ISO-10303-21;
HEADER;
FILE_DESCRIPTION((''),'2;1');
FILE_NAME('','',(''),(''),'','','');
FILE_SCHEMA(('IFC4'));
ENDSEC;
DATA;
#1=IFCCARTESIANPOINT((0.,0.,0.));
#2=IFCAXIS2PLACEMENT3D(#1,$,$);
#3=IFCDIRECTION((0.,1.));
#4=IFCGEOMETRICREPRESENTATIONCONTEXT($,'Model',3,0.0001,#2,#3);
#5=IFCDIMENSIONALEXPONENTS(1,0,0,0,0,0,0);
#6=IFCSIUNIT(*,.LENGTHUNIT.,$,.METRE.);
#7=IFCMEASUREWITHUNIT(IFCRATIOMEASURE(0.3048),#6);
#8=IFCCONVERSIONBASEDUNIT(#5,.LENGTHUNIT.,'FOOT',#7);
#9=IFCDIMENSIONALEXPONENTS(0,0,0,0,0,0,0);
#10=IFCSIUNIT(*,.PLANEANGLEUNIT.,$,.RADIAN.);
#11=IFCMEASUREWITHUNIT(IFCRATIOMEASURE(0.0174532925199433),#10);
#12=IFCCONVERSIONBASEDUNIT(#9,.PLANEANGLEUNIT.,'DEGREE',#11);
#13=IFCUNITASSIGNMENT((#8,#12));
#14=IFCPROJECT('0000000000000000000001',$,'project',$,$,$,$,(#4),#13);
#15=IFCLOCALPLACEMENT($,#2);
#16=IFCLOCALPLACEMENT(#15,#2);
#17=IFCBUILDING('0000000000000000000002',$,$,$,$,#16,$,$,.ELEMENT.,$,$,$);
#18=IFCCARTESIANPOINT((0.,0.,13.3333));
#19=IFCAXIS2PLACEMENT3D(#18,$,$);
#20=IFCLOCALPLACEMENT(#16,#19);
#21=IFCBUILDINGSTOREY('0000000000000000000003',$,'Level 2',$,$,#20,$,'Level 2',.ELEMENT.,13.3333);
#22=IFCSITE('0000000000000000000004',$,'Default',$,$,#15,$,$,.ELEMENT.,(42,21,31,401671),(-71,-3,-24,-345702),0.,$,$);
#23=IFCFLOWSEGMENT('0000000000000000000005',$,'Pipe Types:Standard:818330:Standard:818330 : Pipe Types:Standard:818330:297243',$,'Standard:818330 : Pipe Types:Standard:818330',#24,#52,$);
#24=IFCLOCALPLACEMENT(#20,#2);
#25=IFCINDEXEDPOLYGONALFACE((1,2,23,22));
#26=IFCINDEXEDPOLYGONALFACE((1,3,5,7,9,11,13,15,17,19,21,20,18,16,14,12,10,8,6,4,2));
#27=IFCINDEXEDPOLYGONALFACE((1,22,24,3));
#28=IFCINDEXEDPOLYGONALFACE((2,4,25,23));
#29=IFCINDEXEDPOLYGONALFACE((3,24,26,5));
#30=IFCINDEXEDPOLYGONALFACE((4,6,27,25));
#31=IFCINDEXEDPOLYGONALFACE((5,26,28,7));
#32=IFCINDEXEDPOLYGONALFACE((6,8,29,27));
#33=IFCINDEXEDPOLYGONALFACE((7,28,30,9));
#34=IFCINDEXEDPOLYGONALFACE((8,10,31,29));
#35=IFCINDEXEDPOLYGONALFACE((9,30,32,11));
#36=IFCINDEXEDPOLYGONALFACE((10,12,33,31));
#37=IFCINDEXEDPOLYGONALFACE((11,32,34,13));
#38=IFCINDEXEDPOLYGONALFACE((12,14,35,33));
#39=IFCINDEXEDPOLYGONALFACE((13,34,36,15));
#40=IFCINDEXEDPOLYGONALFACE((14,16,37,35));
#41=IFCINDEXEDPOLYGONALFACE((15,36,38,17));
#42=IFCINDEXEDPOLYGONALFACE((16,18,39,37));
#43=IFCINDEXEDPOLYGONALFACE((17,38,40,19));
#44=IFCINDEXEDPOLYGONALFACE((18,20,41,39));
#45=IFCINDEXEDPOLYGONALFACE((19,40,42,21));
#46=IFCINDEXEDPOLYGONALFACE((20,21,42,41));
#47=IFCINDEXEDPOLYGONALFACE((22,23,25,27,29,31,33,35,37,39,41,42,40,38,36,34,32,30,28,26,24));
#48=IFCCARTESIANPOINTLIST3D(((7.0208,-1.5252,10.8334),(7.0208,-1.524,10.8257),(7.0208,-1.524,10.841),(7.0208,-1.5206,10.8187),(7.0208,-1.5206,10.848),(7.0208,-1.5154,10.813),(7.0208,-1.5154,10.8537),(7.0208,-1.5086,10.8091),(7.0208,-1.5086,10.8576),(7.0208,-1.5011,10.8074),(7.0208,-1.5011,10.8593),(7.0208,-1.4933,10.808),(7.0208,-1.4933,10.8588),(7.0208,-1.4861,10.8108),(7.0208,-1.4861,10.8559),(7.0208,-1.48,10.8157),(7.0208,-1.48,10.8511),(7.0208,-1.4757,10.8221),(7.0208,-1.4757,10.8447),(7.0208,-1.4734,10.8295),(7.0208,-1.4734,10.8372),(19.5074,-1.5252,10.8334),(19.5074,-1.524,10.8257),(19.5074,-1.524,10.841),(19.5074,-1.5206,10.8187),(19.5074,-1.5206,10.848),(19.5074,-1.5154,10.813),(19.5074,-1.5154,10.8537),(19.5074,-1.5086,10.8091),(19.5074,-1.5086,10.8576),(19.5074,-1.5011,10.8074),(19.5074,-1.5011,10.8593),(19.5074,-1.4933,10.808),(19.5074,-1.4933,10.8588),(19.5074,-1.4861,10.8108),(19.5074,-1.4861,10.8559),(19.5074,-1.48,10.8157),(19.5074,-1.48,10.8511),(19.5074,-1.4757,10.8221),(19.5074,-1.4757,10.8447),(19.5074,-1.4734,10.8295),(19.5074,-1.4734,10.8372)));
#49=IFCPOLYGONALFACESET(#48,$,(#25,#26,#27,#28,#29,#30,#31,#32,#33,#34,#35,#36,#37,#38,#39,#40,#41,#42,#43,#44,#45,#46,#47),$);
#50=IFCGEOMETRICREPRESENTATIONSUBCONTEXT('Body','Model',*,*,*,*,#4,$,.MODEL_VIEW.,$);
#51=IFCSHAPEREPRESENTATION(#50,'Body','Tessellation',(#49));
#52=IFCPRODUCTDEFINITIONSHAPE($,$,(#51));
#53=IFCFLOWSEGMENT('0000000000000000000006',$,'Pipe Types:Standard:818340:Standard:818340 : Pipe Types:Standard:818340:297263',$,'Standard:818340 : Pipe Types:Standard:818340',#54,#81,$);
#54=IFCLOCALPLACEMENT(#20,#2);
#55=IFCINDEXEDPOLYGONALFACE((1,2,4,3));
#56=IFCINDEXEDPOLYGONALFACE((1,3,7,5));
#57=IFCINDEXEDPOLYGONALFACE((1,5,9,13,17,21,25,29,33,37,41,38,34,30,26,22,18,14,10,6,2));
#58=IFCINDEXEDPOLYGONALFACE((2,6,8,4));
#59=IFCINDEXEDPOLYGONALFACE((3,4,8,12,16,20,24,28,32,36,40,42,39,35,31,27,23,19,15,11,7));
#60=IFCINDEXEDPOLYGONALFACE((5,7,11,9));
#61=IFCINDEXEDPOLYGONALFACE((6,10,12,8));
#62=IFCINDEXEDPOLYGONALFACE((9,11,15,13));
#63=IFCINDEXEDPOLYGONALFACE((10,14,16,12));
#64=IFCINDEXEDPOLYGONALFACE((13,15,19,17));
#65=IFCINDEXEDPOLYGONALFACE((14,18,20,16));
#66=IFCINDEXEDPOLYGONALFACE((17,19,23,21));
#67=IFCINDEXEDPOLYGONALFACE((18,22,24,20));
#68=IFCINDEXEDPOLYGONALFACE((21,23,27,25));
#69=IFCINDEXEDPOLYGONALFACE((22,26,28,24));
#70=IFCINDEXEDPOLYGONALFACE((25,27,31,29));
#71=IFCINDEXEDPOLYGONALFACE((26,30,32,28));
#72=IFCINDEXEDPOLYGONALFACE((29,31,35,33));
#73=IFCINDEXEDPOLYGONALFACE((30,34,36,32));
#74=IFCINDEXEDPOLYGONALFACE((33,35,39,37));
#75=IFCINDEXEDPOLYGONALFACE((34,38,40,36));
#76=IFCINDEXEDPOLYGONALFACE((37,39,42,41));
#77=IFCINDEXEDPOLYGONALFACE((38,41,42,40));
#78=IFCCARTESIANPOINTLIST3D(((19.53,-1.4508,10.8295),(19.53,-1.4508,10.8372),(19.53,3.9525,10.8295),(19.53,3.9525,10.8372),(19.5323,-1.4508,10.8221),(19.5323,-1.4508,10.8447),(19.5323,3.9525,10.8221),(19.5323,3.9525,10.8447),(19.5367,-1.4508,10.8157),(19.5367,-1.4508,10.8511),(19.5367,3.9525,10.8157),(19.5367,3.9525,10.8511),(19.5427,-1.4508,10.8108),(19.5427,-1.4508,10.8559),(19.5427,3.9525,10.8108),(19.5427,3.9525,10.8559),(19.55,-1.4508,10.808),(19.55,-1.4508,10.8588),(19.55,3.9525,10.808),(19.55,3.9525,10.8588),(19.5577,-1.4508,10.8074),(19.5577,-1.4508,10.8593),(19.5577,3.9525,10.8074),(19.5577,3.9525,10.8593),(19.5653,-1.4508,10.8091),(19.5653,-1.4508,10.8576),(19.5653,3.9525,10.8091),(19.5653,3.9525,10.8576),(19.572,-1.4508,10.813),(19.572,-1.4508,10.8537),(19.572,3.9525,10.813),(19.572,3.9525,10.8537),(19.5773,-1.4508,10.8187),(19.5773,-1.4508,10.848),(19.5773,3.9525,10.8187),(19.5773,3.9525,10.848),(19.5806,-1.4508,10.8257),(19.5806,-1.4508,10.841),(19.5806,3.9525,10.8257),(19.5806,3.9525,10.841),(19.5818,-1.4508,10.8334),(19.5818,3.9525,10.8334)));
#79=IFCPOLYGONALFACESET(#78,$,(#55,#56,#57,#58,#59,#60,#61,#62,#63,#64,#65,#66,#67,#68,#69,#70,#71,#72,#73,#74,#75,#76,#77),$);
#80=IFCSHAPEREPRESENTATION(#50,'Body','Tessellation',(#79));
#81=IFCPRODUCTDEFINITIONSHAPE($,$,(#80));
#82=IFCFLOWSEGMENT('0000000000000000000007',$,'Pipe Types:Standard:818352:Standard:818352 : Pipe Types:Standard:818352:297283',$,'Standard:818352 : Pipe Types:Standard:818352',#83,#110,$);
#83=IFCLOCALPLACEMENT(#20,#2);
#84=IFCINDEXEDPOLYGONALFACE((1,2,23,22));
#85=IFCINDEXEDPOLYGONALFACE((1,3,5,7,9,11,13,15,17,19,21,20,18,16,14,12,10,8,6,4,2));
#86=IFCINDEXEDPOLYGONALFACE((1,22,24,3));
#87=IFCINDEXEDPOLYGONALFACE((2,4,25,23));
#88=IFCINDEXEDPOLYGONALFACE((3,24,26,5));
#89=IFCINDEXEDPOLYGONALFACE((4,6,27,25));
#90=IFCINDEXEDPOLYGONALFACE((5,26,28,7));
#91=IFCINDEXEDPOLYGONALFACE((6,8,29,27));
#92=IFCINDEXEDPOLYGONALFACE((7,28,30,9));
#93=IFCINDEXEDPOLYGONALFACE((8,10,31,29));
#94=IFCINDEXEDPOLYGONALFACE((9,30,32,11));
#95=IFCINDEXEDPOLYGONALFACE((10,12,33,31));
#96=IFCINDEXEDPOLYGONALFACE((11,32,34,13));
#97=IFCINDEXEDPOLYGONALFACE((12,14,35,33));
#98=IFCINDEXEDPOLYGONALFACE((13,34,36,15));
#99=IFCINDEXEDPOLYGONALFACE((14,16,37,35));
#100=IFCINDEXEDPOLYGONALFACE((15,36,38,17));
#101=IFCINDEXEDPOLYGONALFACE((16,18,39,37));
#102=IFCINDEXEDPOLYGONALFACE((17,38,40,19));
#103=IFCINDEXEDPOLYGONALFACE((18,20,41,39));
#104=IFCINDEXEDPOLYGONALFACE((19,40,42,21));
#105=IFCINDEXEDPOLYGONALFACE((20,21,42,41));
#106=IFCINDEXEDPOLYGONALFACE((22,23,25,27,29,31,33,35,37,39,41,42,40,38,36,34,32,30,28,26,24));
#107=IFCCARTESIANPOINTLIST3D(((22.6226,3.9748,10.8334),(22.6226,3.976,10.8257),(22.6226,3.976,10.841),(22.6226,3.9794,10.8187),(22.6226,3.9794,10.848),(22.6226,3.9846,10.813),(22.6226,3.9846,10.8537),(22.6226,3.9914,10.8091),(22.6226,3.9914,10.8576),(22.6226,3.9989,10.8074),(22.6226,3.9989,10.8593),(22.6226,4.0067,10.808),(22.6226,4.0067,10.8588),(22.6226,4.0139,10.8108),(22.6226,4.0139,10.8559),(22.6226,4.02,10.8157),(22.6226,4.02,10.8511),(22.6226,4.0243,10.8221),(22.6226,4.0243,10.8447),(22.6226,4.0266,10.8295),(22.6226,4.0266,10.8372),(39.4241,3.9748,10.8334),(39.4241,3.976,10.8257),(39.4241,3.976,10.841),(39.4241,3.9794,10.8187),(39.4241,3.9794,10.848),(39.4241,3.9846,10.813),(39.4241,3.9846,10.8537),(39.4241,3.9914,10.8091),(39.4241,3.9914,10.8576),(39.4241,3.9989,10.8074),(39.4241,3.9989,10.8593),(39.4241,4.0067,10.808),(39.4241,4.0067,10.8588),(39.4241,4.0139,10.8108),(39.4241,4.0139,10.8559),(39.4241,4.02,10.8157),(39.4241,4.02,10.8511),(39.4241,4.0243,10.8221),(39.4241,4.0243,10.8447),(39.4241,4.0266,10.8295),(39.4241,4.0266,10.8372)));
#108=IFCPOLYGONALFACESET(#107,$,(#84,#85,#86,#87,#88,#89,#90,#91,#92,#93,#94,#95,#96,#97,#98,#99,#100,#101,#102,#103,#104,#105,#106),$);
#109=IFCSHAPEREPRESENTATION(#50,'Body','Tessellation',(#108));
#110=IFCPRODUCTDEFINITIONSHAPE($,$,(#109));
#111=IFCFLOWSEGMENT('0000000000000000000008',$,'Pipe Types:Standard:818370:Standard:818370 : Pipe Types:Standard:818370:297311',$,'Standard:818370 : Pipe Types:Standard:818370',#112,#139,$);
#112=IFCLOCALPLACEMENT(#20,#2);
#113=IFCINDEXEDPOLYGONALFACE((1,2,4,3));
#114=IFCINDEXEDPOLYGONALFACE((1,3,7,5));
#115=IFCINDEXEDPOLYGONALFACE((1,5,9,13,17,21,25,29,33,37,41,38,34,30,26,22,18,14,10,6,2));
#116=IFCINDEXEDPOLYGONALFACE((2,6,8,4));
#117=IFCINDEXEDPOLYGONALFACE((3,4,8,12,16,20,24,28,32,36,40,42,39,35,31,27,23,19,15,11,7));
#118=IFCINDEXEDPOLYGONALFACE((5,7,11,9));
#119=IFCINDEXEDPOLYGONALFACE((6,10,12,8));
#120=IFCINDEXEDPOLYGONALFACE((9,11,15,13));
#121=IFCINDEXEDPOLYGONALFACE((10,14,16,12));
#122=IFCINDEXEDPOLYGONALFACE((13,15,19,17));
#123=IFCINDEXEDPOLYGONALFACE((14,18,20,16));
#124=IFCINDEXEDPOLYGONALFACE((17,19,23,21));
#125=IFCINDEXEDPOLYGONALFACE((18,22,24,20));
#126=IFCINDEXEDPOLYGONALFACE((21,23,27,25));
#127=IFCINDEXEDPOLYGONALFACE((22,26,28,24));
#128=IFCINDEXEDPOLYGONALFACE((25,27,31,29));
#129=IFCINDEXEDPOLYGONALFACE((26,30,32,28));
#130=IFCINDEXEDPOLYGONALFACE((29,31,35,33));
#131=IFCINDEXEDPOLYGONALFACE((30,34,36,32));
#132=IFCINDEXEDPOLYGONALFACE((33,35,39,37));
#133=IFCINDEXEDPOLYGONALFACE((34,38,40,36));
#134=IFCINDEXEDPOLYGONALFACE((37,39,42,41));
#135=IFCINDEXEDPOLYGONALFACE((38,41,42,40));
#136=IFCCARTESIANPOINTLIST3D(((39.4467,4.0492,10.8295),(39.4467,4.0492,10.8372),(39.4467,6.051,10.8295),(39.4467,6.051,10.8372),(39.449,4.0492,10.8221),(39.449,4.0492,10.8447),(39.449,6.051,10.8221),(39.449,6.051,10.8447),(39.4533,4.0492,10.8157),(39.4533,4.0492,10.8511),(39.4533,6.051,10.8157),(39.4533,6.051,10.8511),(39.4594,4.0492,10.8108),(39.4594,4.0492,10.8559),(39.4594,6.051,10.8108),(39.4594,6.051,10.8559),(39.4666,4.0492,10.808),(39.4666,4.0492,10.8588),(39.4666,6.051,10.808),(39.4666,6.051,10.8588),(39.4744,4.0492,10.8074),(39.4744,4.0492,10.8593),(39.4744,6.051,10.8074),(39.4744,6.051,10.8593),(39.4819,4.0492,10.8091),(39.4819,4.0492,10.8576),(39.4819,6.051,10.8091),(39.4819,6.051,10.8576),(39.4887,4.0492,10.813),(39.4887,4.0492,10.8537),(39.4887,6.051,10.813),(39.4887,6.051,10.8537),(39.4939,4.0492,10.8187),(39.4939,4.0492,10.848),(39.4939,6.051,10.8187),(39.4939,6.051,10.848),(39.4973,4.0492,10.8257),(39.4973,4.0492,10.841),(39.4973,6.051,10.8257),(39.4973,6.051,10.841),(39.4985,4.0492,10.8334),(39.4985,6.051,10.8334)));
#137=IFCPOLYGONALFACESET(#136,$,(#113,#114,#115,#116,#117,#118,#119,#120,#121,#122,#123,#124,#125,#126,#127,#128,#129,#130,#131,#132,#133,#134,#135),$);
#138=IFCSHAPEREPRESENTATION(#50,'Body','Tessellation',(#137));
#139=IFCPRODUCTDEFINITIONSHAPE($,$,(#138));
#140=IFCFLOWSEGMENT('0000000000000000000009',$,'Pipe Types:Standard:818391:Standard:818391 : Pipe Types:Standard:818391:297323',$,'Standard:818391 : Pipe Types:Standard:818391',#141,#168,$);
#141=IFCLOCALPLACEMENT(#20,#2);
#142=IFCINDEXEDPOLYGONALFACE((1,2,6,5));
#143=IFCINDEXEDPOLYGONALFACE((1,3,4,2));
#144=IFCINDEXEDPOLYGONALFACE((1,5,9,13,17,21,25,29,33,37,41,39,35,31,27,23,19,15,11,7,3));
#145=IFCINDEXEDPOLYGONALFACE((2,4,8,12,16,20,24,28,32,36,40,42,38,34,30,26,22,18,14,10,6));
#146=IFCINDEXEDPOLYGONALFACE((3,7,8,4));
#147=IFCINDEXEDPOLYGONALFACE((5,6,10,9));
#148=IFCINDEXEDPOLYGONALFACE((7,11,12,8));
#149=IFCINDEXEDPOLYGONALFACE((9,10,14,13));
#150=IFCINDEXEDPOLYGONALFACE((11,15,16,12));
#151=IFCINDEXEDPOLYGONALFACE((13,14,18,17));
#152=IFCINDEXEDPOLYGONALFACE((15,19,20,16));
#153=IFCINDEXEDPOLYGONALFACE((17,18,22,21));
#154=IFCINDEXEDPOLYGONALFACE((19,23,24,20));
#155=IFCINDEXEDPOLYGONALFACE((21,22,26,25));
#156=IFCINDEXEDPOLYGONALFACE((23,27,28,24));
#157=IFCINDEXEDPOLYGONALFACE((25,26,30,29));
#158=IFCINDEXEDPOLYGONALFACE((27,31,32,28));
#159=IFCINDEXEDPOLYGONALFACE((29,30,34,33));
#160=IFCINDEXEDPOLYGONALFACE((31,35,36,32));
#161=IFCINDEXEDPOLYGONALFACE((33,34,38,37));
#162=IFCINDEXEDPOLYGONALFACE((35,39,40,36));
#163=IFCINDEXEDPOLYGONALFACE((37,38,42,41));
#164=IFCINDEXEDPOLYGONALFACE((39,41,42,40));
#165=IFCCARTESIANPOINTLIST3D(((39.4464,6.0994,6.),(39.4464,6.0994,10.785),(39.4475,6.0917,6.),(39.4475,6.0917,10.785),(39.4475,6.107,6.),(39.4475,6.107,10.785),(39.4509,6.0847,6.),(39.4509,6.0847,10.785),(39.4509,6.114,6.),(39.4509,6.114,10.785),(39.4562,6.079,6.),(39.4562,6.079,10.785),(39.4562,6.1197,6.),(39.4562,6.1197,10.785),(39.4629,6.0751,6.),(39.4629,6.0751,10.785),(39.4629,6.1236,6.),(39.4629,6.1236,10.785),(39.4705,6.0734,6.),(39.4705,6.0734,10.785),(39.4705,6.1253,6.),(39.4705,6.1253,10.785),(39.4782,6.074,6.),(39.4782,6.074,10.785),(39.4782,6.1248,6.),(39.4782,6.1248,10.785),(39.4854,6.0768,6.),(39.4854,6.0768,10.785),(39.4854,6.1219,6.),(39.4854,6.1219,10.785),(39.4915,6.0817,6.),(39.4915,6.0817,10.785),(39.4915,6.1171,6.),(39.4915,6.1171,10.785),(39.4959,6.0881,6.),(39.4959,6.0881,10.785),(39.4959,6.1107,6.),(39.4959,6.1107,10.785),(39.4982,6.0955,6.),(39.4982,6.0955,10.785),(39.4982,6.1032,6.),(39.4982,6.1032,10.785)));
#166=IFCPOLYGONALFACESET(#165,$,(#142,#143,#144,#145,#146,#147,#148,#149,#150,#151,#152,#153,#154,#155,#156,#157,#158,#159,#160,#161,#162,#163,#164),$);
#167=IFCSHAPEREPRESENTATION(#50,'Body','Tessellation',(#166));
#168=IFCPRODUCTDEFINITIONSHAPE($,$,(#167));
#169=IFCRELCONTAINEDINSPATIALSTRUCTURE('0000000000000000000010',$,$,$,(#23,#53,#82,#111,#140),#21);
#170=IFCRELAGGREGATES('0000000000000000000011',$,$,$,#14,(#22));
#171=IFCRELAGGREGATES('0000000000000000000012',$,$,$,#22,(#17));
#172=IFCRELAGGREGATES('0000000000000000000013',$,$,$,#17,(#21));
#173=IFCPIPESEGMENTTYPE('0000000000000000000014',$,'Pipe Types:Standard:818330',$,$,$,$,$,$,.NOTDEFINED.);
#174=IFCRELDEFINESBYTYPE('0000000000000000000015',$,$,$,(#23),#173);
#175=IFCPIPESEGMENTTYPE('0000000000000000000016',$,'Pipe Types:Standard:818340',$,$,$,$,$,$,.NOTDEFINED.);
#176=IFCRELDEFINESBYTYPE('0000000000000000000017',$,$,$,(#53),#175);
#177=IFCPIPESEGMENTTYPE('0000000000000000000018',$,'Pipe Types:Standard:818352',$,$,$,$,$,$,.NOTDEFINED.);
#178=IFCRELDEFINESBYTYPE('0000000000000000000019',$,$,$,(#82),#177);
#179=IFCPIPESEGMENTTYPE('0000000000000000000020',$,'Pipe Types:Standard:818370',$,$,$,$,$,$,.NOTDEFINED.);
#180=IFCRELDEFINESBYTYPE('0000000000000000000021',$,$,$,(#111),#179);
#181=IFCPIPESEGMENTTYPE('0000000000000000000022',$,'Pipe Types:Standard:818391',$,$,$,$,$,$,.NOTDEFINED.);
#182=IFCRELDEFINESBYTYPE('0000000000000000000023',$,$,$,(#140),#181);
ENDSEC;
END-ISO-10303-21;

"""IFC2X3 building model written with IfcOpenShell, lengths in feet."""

from ifc_helpers import new_model, entity, si_unit, converted_unit, direction, frame, origin, origin_2d_with_axis, place, context, subcontext, project, spatial, circle, extrude, source, transform, mapped, type_object, type_shapes, element, save


model = new_model("IFC2X3")

# Units and contexts
model_context = context("Model", 3, precision=0.0001, world=origin(), true_north=direction((0.0, 1.0)))
body_context = subcontext(model_context, "Body", "Model", "MODEL_VIEW")
ifc_project = project(units=[converted_unit("LENGTHUNIT", "FOOT", entity("IfcRatioMeasure", 0.3048), si_unit("LENGTHUNIT", "METRE"), dimensions=[1, 0, 0, 0, 0, 0, 0]), converted_unit("PLANEANGLEUNIT", "DEGREE", entity("IfcRatioMeasure", 0.0174532925199433), si_unit("PLANEANGLEUNIT", "RADIAN"), dimensions=[0, 0, 0, 0, 0, 0, 0])], contexts=[model_context])

# Site, building, storey
site_placement = place(None, origin())
site = spatial("IfcSite", under=ifc_project, at=site_placement, Name="Default", CompositionType="ELEMENT", RefLatitude=(42, 21, 31, 401671), RefLongitude=(-71, -3, -24, -345702), RefElevation=0.0)
building_placement = place(site_placement, origin())
building = spatial("IfcBuilding", under=site, at=building_placement, CompositionType="ELEMENT")
storey_placement = place(building_placement, frame((0.0, 0.0, 13.3333)))
storey = spatial("IfcBuildingStorey", under=building, at=storey_placement, Name="Level 2", LongName="Level 2", CompositionType="ELEMENT", Elevation=13.3333)

# Flow segments
pipe_segment_type_1 = type_object("IfcPipeSegmentType", Name="Pipe Types:Standard:818330", PredefinedType="NOTDEFINED")
shared_shape_1 = source(origin(), body_context, "Body", "SweptSolid", [
    extrude(circle(Radius=0.026, at=origin_2d_with_axis()), frame((7.0208, -1.4991, 24.1667), z_axis=(1.0, 0.0, 0.0), x_axis=(0.0, -1.0, 0.0)), (0.0, 0.0, 1.0), 12.4867),
])
type_shapes(pipe_segment_type_1, [shared_shape_1])
flow_segment_1_placement = place(building_placement, origin())
element("IfcFlowSegment", 1, at=flow_segment_1_placement, inside=storey, type_object=pipe_segment_type_1, Name="Pipe Types:Standard:818330:Standard:818330 : Pipe Types:Standard:818330:297243", ObjectType="Standard:818330 : Pipe Types:Standard:818330", context=body_context, shape_type="MappedRepresentation", body=[
    mapped(shared_shape_1, transform((0.0, 0.0, 0.0), scale=1.0)),
])
pipe_segment_type_2 = type_object("IfcPipeSegmentType", Name="Pipe Types:Standard:818340", PredefinedType="NOTDEFINED")
shared_shape_2 = source(origin(), body_context, "Body", "SweptSolid", [
    extrude(circle(Radius=0.026, at=origin_2d_with_axis()), frame((19.5558, -1.4508, 24.1667), z_axis=(0.0, 1.0, 0.0), x_axis=(1.0, 0.0, 0.0)), (0.0, 0.0, 1.0), 5.4033),
])
type_shapes(pipe_segment_type_2, [shared_shape_2])
flow_segment_2_placement = place(building_placement, origin())
element("IfcFlowSegment", 2, at=flow_segment_2_placement, inside=storey, type_object=pipe_segment_type_2, Name="Pipe Types:Standard:818340:Standard:818340 : Pipe Types:Standard:818340:297263", ObjectType="Standard:818340 : Pipe Types:Standard:818340", context=body_context, shape_type="MappedRepresentation", body=[
    mapped(shared_shape_2, transform((0.0, 0.0, 0.0), scale=1.0)),
])
pipe_segment_type_3 = type_object("IfcPipeSegmentType", Name="Pipe Types:Standard:818352", PredefinedType="NOTDEFINED")
shared_shape_3 = source(origin(), body_context, "Body", "SweptSolid", [
    extrude(circle(Radius=0.026, at=origin_2d_with_axis()), frame((22.6226, 4.0009, 24.1667), z_axis=(1.0, 0.0, 0.0), x_axis=(0.0, -1.0, 0.0)), (0.0, 0.0, 1.0), 16.8014),
])
type_shapes(pipe_segment_type_3, [shared_shape_3])
flow_segment_3_placement = place(building_placement, origin())
element("IfcFlowSegment", 3, at=flow_segment_3_placement, inside=storey, type_object=pipe_segment_type_3, Name="Pipe Types:Standard:818352:Standard:818352 : Pipe Types:Standard:818352:297283", ObjectType="Standard:818352 : Pipe Types:Standard:818352", context=body_context, shape_type="MappedRepresentation", body=[
    mapped(shared_shape_3, transform((0.0, 0.0, 0.0), scale=1.0)),
])
pipe_segment_type_4 = type_object("IfcPipeSegmentType", Name="Pipe Types:Standard:818370", PredefinedType="NOTDEFINED")
shared_shape_4 = source(origin(), body_context, "Body", "SweptSolid", [
    extrude(circle(Radius=0.026, at=origin_2d_with_axis()), frame((39.4724, 4.0492, 24.1667), z_axis=(0.0, 1.0, 0.0), x_axis=(1.0, 0.0, 0.0)), (0.0, 0.0, 1.0), 2.0018),
])
type_shapes(pipe_segment_type_4, [shared_shape_4])
flow_segment_4_placement = place(building_placement, origin())
element("IfcFlowSegment", 4, at=flow_segment_4_placement, inside=storey, type_object=pipe_segment_type_4, Name="Pipe Types:Standard:818370:Standard:818370 : Pipe Types:Standard:818370:297311", ObjectType="Standard:818370 : Pipe Types:Standard:818370", context=body_context, shape_type="MappedRepresentation", body=[
    mapped(shared_shape_4, transform((0.0, 0.0, 0.0), scale=1.0)),
])
pipe_segment_type_5 = type_object("IfcPipeSegmentType", Name="Pipe Types:Standard:818391", PredefinedType="NOTDEFINED")
shared_shape_5 = source(origin(), body_context, "Body", "SweptSolid", [
    extrude(circle(Radius=0.026, at=origin_2d_with_axis()), frame((39.4724, 6.0994, 19.3333), z_axis=(0.0, 0.0, 1.0), x_axis=(-1.0, 0.0, 0.0)), (0.0, 0.0, 1.0), 4.785),
])
type_shapes(pipe_segment_type_5, [shared_shape_5])
flow_segment_5_placement = place(building_placement, origin())
element("IfcFlowSegment", 5, at=flow_segment_5_placement, inside=storey, type_object=pipe_segment_type_5, Name="Pipe Types:Standard:818391:Standard:818391 : Pipe Types:Standard:818391:297323", ObjectType="Standard:818391 : Pipe Types:Standard:818391", context=body_context, shape_type="MappedRepresentation", body=[
    mapped(shared_shape_5, transform((0.0, 0.0, 0.0), scale=1.0)),
])

save(model, "model.ifc")
